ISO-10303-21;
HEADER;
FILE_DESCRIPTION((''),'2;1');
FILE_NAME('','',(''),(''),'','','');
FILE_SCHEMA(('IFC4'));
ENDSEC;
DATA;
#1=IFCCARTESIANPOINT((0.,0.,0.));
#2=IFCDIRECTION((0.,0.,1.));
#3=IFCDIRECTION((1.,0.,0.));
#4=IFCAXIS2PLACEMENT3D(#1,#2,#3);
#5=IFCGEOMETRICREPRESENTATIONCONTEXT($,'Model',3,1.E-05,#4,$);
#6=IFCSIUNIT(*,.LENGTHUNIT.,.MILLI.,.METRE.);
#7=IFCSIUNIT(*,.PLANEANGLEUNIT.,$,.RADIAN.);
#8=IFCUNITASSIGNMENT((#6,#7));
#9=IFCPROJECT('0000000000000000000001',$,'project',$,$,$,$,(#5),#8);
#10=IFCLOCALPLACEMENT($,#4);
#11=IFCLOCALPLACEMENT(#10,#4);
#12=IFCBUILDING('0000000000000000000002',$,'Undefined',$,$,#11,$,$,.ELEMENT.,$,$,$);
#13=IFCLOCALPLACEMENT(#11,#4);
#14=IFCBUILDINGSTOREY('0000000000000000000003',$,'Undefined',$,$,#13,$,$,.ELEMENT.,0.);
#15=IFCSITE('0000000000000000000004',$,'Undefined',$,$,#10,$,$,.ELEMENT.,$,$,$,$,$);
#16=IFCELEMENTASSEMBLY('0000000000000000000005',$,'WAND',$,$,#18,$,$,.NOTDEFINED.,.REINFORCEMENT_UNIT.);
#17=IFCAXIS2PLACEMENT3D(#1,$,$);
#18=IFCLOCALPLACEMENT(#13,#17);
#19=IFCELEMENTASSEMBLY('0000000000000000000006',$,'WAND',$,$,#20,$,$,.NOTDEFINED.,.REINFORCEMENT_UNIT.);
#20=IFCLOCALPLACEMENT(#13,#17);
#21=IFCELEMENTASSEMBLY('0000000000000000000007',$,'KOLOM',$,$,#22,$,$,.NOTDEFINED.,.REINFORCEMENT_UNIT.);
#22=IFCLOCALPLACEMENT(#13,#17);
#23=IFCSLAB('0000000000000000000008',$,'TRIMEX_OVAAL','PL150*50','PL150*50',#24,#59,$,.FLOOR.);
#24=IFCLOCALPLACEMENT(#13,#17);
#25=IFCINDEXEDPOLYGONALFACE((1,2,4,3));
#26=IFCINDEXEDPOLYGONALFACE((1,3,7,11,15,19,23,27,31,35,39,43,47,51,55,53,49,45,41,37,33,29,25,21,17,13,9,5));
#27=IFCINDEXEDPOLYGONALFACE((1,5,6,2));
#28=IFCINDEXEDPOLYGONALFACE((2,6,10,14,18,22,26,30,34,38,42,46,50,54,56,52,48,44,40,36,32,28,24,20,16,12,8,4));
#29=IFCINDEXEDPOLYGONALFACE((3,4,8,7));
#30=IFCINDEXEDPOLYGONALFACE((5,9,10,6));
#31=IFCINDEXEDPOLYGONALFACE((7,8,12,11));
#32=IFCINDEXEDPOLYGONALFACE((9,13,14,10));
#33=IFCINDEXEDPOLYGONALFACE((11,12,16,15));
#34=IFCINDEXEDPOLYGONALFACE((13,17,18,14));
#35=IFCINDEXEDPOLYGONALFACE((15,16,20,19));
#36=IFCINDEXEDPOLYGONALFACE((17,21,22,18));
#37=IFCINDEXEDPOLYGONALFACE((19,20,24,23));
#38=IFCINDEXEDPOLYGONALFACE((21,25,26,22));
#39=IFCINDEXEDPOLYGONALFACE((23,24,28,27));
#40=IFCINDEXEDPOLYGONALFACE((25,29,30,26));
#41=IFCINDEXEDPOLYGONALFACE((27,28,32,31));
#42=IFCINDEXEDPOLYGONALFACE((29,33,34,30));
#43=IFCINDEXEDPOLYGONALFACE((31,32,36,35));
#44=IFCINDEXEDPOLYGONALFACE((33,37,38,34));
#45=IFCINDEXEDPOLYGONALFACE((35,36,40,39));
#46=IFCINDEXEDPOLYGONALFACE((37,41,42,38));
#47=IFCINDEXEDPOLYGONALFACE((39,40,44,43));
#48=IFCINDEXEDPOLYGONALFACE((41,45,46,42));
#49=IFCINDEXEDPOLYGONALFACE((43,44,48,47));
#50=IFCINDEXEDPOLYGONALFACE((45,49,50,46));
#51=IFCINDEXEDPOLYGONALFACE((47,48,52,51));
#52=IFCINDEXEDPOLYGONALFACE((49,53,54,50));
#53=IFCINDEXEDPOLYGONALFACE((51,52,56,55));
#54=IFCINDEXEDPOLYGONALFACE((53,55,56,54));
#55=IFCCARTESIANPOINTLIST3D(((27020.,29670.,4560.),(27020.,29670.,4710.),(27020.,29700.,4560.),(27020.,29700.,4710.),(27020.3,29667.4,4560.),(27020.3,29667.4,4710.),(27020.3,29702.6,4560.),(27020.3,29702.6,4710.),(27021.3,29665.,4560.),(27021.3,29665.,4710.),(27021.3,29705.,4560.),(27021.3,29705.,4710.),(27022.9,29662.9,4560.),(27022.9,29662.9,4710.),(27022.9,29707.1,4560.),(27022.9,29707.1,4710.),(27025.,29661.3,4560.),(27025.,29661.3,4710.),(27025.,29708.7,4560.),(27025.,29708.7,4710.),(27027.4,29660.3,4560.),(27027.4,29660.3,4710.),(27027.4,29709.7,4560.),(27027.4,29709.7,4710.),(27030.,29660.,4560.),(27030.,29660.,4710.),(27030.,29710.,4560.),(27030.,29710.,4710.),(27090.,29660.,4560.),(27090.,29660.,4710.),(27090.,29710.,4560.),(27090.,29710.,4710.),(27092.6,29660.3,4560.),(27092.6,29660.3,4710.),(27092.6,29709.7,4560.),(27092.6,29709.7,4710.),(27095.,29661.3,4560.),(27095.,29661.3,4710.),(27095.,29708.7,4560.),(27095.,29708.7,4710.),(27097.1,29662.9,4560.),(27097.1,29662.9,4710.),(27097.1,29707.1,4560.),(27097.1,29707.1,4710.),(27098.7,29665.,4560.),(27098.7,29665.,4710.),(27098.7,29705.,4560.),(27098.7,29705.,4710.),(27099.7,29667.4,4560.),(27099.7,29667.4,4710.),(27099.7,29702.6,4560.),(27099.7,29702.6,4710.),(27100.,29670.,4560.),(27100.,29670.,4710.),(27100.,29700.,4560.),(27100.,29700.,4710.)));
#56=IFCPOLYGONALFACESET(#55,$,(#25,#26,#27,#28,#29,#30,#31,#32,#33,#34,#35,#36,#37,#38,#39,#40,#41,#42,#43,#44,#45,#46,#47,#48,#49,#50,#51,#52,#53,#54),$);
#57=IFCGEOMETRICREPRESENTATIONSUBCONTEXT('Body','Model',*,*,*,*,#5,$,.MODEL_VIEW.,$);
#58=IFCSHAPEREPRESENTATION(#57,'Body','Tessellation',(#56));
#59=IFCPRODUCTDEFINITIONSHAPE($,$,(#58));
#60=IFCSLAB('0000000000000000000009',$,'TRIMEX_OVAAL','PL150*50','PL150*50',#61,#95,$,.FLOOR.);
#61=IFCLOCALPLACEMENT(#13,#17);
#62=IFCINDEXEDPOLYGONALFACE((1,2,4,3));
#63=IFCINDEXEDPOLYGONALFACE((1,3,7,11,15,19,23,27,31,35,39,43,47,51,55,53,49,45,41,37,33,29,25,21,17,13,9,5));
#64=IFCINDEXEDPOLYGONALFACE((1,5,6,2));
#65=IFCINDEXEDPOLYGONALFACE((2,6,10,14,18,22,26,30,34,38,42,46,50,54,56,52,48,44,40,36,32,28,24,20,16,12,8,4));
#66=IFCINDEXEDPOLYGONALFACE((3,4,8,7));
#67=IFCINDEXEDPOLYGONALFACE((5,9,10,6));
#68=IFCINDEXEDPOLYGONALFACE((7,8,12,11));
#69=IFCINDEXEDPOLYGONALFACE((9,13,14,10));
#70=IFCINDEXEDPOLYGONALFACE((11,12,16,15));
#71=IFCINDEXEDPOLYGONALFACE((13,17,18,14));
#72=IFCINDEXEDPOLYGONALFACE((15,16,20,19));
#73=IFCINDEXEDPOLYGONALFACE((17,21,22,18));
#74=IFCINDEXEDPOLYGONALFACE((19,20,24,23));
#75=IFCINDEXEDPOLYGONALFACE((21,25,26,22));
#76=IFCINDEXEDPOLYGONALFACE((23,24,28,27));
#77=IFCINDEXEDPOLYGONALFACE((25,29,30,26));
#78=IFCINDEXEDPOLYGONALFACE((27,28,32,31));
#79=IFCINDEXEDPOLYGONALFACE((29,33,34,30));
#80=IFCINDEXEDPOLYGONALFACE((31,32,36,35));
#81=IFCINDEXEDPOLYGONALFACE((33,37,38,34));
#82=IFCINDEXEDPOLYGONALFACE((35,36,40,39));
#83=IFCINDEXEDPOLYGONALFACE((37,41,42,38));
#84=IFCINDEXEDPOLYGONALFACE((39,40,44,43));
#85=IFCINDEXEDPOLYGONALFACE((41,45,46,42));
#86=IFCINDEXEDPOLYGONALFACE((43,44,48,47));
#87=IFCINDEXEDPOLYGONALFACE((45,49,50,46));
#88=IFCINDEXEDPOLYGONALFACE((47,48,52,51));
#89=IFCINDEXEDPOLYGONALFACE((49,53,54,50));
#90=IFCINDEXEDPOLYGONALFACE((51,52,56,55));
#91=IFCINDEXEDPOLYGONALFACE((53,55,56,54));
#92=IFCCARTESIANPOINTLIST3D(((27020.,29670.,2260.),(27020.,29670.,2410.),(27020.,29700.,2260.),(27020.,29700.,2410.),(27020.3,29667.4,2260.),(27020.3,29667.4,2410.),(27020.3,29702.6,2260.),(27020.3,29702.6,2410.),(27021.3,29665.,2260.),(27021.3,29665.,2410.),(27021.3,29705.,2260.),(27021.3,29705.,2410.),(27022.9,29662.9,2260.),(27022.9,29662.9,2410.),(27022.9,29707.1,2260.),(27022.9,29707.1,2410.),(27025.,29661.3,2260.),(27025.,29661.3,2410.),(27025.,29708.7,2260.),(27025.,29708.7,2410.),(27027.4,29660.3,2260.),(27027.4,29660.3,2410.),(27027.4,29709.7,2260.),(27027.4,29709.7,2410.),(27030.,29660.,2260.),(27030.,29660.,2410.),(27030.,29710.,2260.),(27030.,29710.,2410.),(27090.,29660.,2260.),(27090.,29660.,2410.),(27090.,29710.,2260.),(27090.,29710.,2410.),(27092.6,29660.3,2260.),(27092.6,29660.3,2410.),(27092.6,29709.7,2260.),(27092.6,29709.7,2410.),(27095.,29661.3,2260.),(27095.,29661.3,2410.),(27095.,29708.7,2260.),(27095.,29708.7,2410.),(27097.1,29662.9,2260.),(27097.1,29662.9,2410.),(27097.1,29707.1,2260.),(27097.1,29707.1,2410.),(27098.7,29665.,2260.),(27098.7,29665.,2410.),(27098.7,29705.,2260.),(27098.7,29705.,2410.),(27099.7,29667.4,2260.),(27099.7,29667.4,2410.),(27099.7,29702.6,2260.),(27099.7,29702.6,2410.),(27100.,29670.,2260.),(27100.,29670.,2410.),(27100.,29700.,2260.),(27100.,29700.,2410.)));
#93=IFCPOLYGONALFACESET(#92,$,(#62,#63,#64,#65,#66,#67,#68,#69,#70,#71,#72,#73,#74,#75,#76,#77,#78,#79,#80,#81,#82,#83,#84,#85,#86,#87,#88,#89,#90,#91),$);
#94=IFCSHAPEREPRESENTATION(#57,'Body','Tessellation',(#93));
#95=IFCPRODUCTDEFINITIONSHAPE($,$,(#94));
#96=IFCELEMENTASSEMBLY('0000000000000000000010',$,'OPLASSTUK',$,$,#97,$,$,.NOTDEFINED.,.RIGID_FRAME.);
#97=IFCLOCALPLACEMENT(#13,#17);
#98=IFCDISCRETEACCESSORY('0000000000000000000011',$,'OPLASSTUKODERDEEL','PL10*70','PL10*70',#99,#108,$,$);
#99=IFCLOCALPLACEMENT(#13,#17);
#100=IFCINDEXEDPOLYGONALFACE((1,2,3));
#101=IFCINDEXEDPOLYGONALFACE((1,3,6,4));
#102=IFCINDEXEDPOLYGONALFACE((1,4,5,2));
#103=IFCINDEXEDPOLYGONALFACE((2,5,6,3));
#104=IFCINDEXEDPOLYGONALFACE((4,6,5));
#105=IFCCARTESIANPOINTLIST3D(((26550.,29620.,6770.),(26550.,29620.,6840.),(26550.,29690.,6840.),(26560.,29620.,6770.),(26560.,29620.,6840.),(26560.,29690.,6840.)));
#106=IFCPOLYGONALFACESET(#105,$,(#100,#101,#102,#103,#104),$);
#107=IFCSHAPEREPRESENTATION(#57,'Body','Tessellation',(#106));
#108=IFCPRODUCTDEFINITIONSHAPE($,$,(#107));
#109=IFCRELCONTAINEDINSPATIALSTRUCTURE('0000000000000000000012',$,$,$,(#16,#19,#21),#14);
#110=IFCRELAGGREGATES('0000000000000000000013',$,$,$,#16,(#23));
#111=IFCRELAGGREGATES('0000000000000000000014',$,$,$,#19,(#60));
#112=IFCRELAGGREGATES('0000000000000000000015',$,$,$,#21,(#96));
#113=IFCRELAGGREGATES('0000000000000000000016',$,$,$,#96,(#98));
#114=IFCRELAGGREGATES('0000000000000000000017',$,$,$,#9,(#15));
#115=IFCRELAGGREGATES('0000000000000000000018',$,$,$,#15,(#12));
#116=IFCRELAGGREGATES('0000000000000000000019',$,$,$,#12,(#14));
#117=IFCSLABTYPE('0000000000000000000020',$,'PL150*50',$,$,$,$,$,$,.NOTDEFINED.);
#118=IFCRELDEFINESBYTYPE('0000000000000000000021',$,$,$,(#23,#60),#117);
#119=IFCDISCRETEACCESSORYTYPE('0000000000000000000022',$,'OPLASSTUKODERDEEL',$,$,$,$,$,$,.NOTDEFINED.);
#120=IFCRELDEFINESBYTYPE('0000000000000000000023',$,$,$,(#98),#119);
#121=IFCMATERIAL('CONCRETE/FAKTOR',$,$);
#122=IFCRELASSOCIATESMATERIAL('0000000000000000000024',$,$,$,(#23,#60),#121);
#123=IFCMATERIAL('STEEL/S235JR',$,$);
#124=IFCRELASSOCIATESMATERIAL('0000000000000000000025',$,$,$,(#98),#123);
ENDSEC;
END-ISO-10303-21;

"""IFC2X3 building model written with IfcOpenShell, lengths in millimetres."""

from ifc_helpers import new_model, si_unit, frame, frame_2d, origin_with_axes, place, context, subcontext, project, spatial, polyline, circle_curve, parameter, trimmed, segment, composite_curve, outline, extrude, material, type_object, element, aggregate, save


model = new_model("IFC2X3")

# Units and contexts
model_context = context("Model", 3, precision=1e-05, world=origin_with_axes())
body_context = subcontext(model_context, "Body", "Model", "MODEL_VIEW")
ifc_project = project(units=[si_unit("LENGTHUNIT", "METRE", prefix="MILLI"), si_unit("PLANEANGLEUNIT", "RADIAN")], contexts=[model_context])

# Site, building, storey
site_placement = place(None, origin_with_axes())
site = spatial("IfcSite", under=ifc_project, at=site_placement, Name="Undefined", CompositionType="ELEMENT")
building_placement = place(site_placement, origin_with_axes())
building = spatial("IfcBuilding", under=site, at=building_placement, Name="Undefined", CompositionType="ELEMENT")
storey_placement = place(building_placement, origin_with_axes())
storey = spatial("IfcBuildingStorey", under=building, at=storey_placement, Name="Undefined", CompositionType="ELEMENT", Elevation=0.0)

# Element assemblies
assembly_1_placement = place(storey_placement, origin_with_axes())
assembly_1 = element("IfcElementAssembly", 1, at=assembly_1_placement, inside=storey, Name="WAND", AssemblyPlace="NOTDEFINED", PredefinedType="REINFORCEMENT_UNIT")
assembly_2_placement = place(storey_placement, origin_with_axes())
assembly_2 = element("IfcElementAssembly", 2, at=assembly_2_placement, inside=storey, Name="WAND", AssemblyPlace="NOTDEFINED", PredefinedType="REINFORCEMENT_UNIT")
ifc_material_1 = material(Name="CONCRETE/FAKTOR")

# Element assembly
assembly_3_placement = place(storey_placement, origin_with_axes())
assembly_3 = element("IfcElementAssembly", 3, at=assembly_3_placement, inside=storey, Name="KOLOM", AssemblyPlace="NOTDEFINED", PredefinedType="REINFORCEMENT_UNIT")

# Slabs
slab_type = type_object("IfcSlabType", Name="PL150*50", PredefinedType="NOTDEFINED")
slab_1_placement = place(assembly_1_placement, frame((27020.0, 29710.0, 4635.0), z_axis=(0.0, 0.0, 1.0), x_axis=(0.0, -1.0, 0.0)))
slab_1 = element("IfcSlab", 4, at=slab_1_placement, type_object=slab_type, material=ifc_material_1, Name="TRIMEX_OVAAL", Description="PL150*50", ObjectType="PL150*50", PredefinedType="FLOOR", context=body_context, shape_type="SweptSolid", body=[
    extrude(outline(composite_curve([segment(trimmed(circle_curve(frame_2d((10.0, 10.0), x_axis=(-1.0, 0.0)), 10.0), [parameter(0.0)], [parameter(1.570796)], True, "PARAMETER"), True, "CONTINUOUS"), segment(polyline([(10.0, 0.0), (40.0, 0.0)]), True, "CONTINUOUS"), segment(trimmed(circle_curve(frame_2d((40.0, 10.0), x_axis=(0.0, -1.0)), 10.0), [parameter(0.0)], [parameter(1.570796)], True, "PARAMETER"), True, "CONTINUOUS"), segment(polyline([(50.0, 10.0), (50.0, 70.0)]), True, "CONTINUOUS"), segment(trimmed(circle_curve(frame_2d((40.0, 70.0), x_axis=(1.0, 0.0)), 10.0), [parameter(0.0)], [parameter(1.570796)], True, "PARAMETER"), True, "CONTINUOUS"), segment(polyline([(40.0, 80.0), (10.0, 80.0)]), True, "CONTINUOUS"), segment(trimmed(circle_curve(frame_2d((10.0, 70.0), x_axis=(0.0, 1.0)), 10.0), [parameter(0.0)], [parameter(1.570796)], True, "PARAMETER"), True, "CONTINUOUS"), segment(polyline([(0.0, 70.0), (0.0, 10.0)]), True, "CONTINUOUS")], self_intersect=True)), frame((0.0, 0.0, -75.0), z_axis=(0.0, 0.0, 1.0), x_axis=(1.0, 0.0, 0.0)), (0.0, 0.0, 1.0), 150.0),
])
aggregate(assembly_1, [slab_1])
slab_2_placement = place(assembly_2_placement, frame((27100.0, 29660.0, 2335.0), z_axis=(0.0, 0.0, 1.0), x_axis=(0.0, 1.0, 0.0)))
slab_2 = element("IfcSlab", 5, at=slab_2_placement, type_object=slab_type, material=ifc_material_1, Name="TRIMEX_OVAAL", Description="PL150*50", ObjectType="PL150*50", PredefinedType="FLOOR", context=body_context, shape_type="SweptSolid", body=[
    extrude(outline(composite_curve([segment(trimmed(circle_curve(frame_2d((10.0, 10.0), x_axis=(-1.0, 0.0)), 10.0), [parameter(0.0)], [parameter(1.570796)], True, "PARAMETER"), True, "CONTINUOUS"), segment(polyline([(10.0, 0.0), (40.0, 0.0)]), True, "CONTINUOUS"), segment(trimmed(circle_curve(frame_2d((40.0, 10.0), x_axis=(0.0, -1.0)), 10.0), [parameter(0.0)], [parameter(1.570796)], True, "PARAMETER"), True, "CONTINUOUS"), segment(polyline([(50.0, 10.0), (50.0, 70.0)]), True, "CONTINUOUS"), segment(trimmed(circle_curve(frame_2d((40.0, 70.0), x_axis=(1.0, 0.0)), 10.0), [parameter(0.0)], [parameter(1.570796)], True, "PARAMETER"), True, "CONTINUOUS"), segment(polyline([(40.0, 80.0), (10.0, 80.0)]), True, "CONTINUOUS"), segment(trimmed(circle_curve(frame_2d((10.0, 70.0), x_axis=(0.0, 1.0)), 10.0), [parameter(0.0)], [parameter(1.570796)], True, "PARAMETER"), True, "CONTINUOUS"), segment(polyline([(0.0, 70.0), (0.0, 10.0)]), True, "CONTINUOUS")], self_intersect=True)), frame((0.0, 0.0, -75.0), z_axis=(0.0, 0.0, 1.0), x_axis=(1.0, 0.0, 0.0)), (0.0, 0.0, 1.0), 150.0),
])
aggregate(assembly_2, [slab_2])

# Element assembly
assembly_4_placement = place(assembly_3_placement, origin_with_axes())
assembly_4 = element("IfcElementAssembly", 6, at=assembly_4_placement, Name="OPLASSTUK", AssemblyPlace="NOTDEFINED", PredefinedType="RIGID_FRAME")
aggregate(assembly_3, [assembly_4])

# Discrete accessory
ifc_material_2 = material(Name="STEEL/S235JR")
discrete_accessory_type = type_object("IfcDiscreteAccessoryType", Name="OPLASSTUKODERDEEL")
discrete_accessory_placement = place(assembly_4_placement, frame((26555.0, 29620.0, 6770.0), z_axis=(-1.0, 0.0, 0.0), x_axis=(0.0, 0.0, 1.0)))
discrete_accessory = element("IfcDiscreteAccessory", 7, at=discrete_accessory_placement, type_object=discrete_accessory_type, material=ifc_material_2, Name="OPLASSTUKODERDEEL", Description="PL10*70", ObjectType="PL10*70", context=body_context, shape_type="SweptSolid", body=[
    extrude(outline(polyline([(0.0, 0.0), (70.0, 0.0), (70.0, 70.0), (0.0, 0.0)])), frame((0.0, 0.0, -5.0), z_axis=(0.0, 0.0, 1.0), x_axis=(1.0, 0.0, 0.0)), (0.0, 0.0, 1.0), 10.0),
])
aggregate(assembly_4, [discrete_accessory])

save(model, "model.ifc")
